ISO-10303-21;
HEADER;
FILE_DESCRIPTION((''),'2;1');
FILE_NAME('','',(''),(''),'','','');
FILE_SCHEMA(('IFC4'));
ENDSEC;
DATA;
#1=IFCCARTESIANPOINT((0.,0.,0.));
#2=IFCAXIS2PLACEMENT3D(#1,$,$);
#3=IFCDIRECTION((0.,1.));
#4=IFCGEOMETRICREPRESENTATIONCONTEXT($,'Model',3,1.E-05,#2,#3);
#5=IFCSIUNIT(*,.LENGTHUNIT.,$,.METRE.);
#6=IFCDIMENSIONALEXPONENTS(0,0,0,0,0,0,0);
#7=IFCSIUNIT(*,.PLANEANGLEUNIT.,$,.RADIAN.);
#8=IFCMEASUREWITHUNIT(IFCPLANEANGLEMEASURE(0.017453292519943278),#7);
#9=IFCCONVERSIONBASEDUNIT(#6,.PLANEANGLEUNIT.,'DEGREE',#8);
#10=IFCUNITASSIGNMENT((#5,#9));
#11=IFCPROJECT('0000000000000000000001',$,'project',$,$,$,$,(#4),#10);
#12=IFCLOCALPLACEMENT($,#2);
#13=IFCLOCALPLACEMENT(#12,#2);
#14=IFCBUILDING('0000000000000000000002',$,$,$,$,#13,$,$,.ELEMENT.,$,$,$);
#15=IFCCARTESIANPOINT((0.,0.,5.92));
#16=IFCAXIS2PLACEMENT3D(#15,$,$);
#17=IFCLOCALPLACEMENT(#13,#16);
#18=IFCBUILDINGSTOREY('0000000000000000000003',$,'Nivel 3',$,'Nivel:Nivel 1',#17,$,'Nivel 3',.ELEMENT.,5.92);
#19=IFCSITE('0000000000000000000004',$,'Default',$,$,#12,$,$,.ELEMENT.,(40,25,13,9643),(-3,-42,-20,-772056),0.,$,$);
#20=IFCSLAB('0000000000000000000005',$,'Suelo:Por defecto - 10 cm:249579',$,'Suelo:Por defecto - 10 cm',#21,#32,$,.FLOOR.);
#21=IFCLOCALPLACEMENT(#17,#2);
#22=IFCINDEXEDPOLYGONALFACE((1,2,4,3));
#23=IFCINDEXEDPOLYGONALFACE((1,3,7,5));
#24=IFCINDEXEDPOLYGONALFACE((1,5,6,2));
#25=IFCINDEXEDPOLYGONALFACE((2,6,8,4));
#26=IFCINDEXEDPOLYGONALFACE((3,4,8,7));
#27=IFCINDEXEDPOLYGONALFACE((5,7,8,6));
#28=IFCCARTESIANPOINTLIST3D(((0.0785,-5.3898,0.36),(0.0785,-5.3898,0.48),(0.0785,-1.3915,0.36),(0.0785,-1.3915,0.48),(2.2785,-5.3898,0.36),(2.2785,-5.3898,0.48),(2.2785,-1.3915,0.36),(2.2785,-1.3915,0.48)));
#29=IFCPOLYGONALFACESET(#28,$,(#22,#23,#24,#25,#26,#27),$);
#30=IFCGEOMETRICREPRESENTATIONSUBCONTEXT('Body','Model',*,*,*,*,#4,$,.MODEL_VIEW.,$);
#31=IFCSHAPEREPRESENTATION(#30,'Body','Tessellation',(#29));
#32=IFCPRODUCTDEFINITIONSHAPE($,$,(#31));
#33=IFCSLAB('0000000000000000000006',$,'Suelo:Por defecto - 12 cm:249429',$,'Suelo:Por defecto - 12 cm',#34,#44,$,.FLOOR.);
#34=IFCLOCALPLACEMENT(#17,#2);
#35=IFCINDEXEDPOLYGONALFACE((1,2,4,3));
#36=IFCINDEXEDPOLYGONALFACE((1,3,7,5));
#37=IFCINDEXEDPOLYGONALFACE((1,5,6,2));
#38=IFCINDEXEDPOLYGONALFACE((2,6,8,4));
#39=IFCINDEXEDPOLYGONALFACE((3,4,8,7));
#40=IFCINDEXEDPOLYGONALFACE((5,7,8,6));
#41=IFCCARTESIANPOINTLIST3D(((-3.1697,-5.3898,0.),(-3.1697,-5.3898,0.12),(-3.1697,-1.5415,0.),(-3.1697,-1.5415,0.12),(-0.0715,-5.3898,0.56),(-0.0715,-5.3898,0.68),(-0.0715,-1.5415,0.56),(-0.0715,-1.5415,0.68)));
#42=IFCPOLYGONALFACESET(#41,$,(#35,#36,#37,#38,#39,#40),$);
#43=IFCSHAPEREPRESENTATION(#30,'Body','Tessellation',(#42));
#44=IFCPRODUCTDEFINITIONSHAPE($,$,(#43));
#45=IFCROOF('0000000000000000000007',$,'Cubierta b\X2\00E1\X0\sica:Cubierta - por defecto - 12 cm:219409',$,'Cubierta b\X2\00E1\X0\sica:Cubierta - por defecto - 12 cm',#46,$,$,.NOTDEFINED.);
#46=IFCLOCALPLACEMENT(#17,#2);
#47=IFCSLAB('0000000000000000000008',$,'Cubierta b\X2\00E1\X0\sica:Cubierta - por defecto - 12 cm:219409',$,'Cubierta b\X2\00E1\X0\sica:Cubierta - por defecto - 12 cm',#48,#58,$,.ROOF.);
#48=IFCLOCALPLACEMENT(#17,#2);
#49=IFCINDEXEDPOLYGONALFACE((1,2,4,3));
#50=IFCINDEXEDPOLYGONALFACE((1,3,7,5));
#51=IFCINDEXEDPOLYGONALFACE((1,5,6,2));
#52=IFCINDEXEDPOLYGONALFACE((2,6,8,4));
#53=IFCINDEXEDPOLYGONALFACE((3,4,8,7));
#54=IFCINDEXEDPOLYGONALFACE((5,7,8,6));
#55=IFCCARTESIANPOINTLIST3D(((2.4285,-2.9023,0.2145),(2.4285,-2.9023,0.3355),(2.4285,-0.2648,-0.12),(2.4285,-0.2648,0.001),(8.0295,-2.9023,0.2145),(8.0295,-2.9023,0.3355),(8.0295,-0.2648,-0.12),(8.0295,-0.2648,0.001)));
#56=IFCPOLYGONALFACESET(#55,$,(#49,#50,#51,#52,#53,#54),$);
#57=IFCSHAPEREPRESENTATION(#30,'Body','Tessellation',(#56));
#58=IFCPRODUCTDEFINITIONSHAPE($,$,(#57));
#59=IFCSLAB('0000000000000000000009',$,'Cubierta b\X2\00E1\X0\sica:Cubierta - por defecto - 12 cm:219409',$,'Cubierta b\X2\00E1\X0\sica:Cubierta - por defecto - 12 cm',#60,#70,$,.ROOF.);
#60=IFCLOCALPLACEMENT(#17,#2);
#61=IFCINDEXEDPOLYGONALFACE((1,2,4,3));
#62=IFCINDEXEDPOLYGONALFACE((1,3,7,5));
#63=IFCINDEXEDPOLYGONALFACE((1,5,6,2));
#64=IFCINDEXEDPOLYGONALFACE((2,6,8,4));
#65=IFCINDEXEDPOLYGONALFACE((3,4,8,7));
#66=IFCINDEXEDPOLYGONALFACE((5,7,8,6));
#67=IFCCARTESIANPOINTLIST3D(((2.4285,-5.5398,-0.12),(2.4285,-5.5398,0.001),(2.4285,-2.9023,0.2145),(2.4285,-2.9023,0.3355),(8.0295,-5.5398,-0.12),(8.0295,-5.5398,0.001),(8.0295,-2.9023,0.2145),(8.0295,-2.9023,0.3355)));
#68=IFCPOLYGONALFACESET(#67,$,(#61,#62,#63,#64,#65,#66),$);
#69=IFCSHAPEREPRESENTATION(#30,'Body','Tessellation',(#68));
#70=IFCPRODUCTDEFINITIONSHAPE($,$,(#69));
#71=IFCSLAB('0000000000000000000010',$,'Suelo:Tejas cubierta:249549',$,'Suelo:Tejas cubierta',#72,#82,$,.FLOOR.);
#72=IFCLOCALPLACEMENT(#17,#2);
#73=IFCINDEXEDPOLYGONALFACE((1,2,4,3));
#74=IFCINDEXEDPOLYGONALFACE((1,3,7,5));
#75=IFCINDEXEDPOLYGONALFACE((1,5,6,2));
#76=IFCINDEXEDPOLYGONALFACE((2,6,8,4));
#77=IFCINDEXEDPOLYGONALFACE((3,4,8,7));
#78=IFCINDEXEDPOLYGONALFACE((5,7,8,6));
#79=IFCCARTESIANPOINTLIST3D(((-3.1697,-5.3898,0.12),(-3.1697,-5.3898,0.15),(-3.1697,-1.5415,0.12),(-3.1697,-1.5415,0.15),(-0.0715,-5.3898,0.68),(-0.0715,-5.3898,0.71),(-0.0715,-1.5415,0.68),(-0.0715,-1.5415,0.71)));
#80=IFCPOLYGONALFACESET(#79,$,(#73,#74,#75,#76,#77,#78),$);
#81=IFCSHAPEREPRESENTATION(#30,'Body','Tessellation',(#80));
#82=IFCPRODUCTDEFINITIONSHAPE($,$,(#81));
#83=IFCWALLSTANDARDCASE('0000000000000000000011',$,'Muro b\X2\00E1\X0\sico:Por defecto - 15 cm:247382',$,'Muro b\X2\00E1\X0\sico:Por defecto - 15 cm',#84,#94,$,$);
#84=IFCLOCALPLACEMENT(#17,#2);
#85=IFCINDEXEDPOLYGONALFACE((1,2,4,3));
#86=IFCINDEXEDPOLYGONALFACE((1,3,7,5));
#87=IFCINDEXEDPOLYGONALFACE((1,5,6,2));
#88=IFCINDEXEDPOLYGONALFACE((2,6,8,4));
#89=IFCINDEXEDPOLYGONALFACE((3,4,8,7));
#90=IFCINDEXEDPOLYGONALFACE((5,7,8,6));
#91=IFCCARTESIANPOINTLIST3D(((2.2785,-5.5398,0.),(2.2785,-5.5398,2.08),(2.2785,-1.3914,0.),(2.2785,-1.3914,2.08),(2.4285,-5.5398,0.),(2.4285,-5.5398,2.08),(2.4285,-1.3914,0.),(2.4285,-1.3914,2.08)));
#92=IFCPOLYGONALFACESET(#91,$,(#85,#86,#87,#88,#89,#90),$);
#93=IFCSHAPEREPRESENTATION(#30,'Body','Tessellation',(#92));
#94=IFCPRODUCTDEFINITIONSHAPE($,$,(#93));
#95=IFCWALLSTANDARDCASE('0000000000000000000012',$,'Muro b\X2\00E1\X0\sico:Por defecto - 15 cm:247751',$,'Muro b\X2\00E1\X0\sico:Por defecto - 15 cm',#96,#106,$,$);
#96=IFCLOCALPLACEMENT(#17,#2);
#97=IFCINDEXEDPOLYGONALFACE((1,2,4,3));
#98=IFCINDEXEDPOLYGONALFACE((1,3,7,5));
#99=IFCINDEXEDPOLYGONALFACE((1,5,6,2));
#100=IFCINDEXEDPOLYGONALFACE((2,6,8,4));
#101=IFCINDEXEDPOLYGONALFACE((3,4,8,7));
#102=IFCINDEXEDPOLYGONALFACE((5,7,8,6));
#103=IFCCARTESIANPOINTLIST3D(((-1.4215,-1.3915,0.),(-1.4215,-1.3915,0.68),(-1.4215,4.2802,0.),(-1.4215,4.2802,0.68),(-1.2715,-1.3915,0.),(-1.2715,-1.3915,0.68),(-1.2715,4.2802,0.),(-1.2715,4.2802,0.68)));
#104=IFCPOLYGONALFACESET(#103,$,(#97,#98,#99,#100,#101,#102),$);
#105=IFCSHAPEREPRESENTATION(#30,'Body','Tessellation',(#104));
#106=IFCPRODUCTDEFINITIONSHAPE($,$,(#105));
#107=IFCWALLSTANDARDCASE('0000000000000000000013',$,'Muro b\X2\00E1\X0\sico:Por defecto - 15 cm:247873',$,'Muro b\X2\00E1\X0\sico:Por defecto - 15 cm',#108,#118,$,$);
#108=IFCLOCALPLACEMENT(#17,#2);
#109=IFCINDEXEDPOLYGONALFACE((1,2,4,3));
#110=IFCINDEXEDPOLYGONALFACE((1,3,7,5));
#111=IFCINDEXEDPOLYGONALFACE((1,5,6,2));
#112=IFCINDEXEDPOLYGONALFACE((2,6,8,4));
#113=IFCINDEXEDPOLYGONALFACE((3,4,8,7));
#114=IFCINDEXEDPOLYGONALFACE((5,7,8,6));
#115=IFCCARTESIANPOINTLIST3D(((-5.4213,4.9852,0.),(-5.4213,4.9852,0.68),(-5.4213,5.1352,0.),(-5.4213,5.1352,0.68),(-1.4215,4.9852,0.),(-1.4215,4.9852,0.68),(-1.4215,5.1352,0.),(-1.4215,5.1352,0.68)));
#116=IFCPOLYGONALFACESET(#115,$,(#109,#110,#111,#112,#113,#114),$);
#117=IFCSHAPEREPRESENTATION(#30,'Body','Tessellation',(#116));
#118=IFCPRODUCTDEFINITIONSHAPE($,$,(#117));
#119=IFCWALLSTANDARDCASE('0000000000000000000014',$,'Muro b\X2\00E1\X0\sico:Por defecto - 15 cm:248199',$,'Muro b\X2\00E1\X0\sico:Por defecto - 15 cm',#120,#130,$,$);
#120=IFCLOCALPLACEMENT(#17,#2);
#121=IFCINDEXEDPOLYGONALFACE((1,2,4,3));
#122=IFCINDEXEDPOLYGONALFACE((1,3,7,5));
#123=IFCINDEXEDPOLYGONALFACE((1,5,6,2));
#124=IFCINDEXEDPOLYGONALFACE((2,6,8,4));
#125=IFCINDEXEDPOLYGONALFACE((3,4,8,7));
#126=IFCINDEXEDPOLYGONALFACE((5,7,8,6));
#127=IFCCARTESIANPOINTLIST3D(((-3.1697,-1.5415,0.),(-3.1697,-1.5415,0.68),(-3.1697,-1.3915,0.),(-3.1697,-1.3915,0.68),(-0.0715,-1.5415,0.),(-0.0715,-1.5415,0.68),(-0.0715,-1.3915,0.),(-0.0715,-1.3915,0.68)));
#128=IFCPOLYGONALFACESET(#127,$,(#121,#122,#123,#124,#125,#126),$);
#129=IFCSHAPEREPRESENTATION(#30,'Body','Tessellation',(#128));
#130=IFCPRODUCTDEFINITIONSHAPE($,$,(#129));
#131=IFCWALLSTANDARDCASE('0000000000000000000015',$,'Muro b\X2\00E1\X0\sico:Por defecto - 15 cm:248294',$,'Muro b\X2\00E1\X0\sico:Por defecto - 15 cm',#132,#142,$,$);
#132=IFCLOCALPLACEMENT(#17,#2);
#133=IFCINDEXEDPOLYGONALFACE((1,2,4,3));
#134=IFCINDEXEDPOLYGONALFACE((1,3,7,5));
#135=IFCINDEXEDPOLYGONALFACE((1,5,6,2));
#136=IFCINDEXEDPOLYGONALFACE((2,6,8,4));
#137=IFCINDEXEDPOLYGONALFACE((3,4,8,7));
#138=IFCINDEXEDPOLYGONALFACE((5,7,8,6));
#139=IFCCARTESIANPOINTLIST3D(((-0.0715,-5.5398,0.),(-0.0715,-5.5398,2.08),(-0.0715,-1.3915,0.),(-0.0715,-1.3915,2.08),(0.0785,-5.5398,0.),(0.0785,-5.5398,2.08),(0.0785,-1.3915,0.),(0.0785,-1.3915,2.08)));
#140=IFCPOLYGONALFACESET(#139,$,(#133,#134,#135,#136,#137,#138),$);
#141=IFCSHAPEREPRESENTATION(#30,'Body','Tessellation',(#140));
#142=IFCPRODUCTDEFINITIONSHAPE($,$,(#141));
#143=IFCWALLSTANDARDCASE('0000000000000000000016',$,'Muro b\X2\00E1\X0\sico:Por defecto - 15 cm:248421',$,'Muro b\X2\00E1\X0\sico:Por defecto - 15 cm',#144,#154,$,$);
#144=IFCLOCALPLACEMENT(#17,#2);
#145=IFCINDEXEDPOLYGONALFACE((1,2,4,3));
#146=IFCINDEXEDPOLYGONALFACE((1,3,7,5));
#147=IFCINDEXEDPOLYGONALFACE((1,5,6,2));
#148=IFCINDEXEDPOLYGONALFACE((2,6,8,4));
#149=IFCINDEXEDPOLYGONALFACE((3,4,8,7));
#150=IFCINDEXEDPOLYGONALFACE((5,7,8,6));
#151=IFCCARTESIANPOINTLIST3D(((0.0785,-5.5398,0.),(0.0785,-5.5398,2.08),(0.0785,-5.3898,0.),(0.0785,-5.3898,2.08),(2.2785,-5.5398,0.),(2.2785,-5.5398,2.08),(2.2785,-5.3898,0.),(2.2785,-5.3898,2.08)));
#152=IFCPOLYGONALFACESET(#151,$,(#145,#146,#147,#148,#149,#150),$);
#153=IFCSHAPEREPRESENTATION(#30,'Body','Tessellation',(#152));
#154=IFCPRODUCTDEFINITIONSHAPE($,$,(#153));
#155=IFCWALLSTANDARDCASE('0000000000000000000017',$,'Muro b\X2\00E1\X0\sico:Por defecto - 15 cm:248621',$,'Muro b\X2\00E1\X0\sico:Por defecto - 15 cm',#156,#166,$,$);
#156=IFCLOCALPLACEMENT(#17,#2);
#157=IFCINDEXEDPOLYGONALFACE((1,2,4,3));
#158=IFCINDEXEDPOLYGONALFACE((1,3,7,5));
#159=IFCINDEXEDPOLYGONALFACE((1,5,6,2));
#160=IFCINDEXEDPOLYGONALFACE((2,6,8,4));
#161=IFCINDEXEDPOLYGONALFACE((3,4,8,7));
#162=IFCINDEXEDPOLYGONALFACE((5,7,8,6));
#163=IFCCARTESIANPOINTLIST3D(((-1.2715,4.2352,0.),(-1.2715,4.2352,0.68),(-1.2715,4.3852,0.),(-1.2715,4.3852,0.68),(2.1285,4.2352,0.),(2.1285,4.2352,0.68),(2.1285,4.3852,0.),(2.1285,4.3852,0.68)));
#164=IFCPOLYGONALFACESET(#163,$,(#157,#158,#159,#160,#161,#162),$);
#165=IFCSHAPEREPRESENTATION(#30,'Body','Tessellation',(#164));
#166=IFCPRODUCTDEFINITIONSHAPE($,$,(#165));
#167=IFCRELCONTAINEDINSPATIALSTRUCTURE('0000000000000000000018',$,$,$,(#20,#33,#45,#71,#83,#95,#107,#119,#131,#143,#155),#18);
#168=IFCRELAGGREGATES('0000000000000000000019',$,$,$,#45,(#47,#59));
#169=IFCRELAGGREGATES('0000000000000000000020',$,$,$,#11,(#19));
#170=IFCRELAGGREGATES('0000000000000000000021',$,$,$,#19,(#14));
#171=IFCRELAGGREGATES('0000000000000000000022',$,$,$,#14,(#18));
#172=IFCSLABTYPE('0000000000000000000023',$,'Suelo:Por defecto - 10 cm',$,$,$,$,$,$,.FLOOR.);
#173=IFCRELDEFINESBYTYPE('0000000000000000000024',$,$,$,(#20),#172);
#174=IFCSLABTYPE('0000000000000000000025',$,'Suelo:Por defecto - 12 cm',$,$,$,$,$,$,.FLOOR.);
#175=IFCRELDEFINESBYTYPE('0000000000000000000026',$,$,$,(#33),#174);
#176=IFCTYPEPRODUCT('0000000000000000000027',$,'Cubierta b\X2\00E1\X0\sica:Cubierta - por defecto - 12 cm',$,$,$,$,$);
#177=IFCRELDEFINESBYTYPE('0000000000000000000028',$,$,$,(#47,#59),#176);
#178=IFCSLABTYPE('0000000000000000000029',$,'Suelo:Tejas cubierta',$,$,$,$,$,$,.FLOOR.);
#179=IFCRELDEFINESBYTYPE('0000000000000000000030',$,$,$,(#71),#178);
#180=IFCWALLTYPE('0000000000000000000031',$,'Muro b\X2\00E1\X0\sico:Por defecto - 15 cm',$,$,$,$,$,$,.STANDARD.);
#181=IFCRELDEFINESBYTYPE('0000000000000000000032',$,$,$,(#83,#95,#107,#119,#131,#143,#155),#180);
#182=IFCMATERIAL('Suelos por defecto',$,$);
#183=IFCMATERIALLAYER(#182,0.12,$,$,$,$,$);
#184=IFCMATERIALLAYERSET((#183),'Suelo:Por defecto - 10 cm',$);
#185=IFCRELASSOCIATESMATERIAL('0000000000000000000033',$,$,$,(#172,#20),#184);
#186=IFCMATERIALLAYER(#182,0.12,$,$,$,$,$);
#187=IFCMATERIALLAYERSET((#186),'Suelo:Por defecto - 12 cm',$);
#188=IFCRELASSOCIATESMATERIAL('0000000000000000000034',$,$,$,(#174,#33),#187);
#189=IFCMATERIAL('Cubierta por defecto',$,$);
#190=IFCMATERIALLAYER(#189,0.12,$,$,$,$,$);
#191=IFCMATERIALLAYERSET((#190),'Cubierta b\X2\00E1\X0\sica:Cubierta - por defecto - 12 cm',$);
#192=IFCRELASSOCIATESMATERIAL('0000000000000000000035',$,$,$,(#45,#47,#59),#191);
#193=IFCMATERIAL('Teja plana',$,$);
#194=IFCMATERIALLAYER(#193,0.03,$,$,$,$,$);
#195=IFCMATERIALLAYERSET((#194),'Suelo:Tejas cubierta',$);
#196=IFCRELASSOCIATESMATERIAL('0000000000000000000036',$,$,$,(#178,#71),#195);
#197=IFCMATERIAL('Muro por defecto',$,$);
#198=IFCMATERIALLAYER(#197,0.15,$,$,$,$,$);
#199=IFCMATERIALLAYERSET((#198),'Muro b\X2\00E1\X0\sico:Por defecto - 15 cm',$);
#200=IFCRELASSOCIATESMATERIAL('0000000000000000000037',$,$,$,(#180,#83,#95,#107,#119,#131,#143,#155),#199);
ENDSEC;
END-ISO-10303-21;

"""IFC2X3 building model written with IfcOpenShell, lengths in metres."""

from ifc_helpers import new_model, entity, si_unit, converted_unit, direction, frame, frame_2d, origin, place, context, subcontext, project, spatial, rectangle, extrude, clip, halfspace, material, layer, layer_set, layer_usage, type_object, element, aggregate, save


model = new_model("IFC2X3")

# Units and contexts
model_context = context("Model", 3, precision=1e-05, world=origin(), true_north=direction((0.0, 1.0)))
body_context = subcontext(model_context, "Body", "Model", "MODEL_VIEW")
ifc_project = project(units=[si_unit("LENGTHUNIT", "METRE"), converted_unit("PLANEANGLEUNIT", "DEGREE", entity("IfcPlaneAngleMeasure", 0.017453292519943278), si_unit("PLANEANGLEUNIT", "RADIAN"), dimensions=[0, 0, 0, 0, 0, 0, 0])], contexts=[model_context])

# Site, building, storey
site_placement = place(None, origin())
site = spatial("IfcSite", under=ifc_project, at=site_placement, Name="Default", CompositionType="ELEMENT", RefLatitude=(40, 25, 13, 9643), RefLongitude=(-3, -42, -20, -772056), RefElevation=0.0)
building_placement = place(site_placement, origin())
building = spatial("IfcBuilding", under=site, at=building_placement, CompositionType="ELEMENT")
storey_placement = place(building_placement, frame((0.0, 0.0, 5.92)))
storey = spatial("IfcBuildingStorey", under=building, at=storey_placement, Name="Nivel 3", ObjectType="Nivel:Nivel 1", LongName="Nivel 3", CompositionType="ELEMENT", Elevation=5.92)

# Slabs
ifc_material_1 = material(Name="Suelos por defecto")
ifc_layer_1 = layer(ifc_material_1, 0.12)
ifc_layer_set_1 = layer_set([ifc_layer_1], Name="Suelo:Por defecto - 10 cm")
ifc_layer_usage_1 = layer_usage(ifc_layer_set_1, "AXIS3", "POSITIVE", 0.0)
slab_type_1 = type_object("IfcSlabType", Name="Suelo:Por defecto - 10 cm", PredefinedType="FLOOR", material=ifc_layer_set_1)
slab_1_placement = place(storey_placement, origin())
element("IfcSlab", 1, at=slab_1_placement, inside=storey, type_object=slab_type_1, material=ifc_layer_usage_1, Name="Suelo:Por defecto - 10 cm:249579", ObjectType="Suelo:Por defecto - 10 cm", PredefinedType="FLOOR", context=body_context, shape_type="SweptSolid", body=[
    extrude(rectangle(XDim=3.9982, YDim=2.2, at=frame_2d((0.0, 0.0), x_axis=(1.0, 0.0))), frame((1.1785, -3.3906, 0.48), z_axis=(0.0, 0.0, -1.0), x_axis=(0.0, 1.0, 0.0)), (0.0, 0.0, 1.0), 0.12),
])
ifc_layer_2 = layer(ifc_material_1, 0.12)
ifc_layer_set_2 = layer_set([ifc_layer_2], Name="Suelo:Por defecto - 12 cm")
slab_type_2 = type_object("IfcSlabType", Name="Suelo:Por defecto - 12 cm", PredefinedType="FLOOR", material=ifc_layer_set_2)
ifc_layer_usage_2 = layer_usage(ifc_layer_set_2, "AXIS3", "POSITIVE", 0.0)
slab_2_placement = place(storey_placement, origin())
element("IfcSlab", 2, at=slab_2_placement, inside=storey, type_object=slab_type_2, material=ifc_layer_usage_2, Name="Suelo:Por defecto - 12 cm:249429", ObjectType="Suelo:Por defecto - 12 cm", PredefinedType="FLOOR", context=body_context, shape_type="SweptSolid", body=[
    clip(clip(extrude(rectangle(XDim=3.1484, YDim=3.8482, at=frame_2d((0.0, 0.0), x_axis=(0.0, 1.0))), frame((-1.6206, -3.4656, 0.4), z_axis=(0.177866, 0.0, -0.984055), x_axis=(0.0, 1.0, 0.0)), (0.0, -0.177866, 0.984055), 0.1219), halfspace(frame((-1.6206, -3.4656, 0.28), z_axis=(0.177866, 0.0, -0.984055), x_axis=(0.0, -1.0, 0.0)), False)), halfspace(frame((-1.6206, -3.4656, 0.4), z_axis=(-0.177866, 0.0, 0.984055), x_axis=(0.0, -1.0, 0.0)), False)),
])

# Roof, slabs
ifc_material_2 = material(Name="Cubierta por defecto")
ifc_layer_3 = layer(ifc_material_2, 0.12)
ifc_layer_set_3 = layer_set([ifc_layer_3], Name="Cubierta básica:Cubierta - por defecto - 12 cm")
roof_placement = place(storey_placement, frame((2.4285, -5.5398, -0.12)))
roof = element("IfcRoof", 3, at=roof_placement, inside=storey, material=ifc_layer_set_3, Name="Cubierta básica:Cubierta - por defecto - 12 cm:219409", ObjectType="Cubierta básica:Cubierta - por defecto - 12 cm", ShapeType="NOTDEFINED")
type_product = type_object("IfcTypeProduct", Name="Cubierta básica:Cubierta - por defecto - 12 cm")
slab_3_placement = place(roof_placement, origin())
slab_3 = element("IfcSlab", 4, at=slab_3_placement, type_object=type_product, material=ifc_layer_set_3, Name="Cubierta básica:Cubierta - por defecto - 12 cm:219409", ObjectType="Cubierta básica:Cubierta - por defecto - 12 cm", PredefinedType="ROOF", context=body_context, shape_type="SweptSolid", body=[
    extrude(rectangle(XDim=2.6586, YDim=5.601, at=frame_2d((0.0, 0.0), x_axis=(0.0, -1.0))), frame((2.8005, 3.9562, 0.1673), z_axis=(0.0, 0.125829, 0.992052), x_axis=(1.0, 0.0, 0.0)), (0.0, -0.125829, 0.992052), 0.121),
])
slab_4_placement = place(roof_placement, origin())
slab_4 = element("IfcSlab", 5, at=slab_4_placement, type_object=type_product, material=ifc_layer_set_3, Name="Cubierta básica:Cubierta - por defecto - 12 cm:219409", ObjectType="Cubierta básica:Cubierta - por defecto - 12 cm", PredefinedType="ROOF", context=body_context, shape_type="SweptSolid", body=[
    extrude(rectangle(XDim=5.601, YDim=2.6586, at=frame_2d((0.0, 0.0), x_axis=(-1.0, 0.0))), frame((2.8005, 1.3187, 0.1673), z_axis=(0.0, -0.125829, 0.992052), x_axis=(1.0, 0.0, 0.0)), (0.0, 0.125829, 0.992052), 0.121),
])
aggregate(roof, [slab_3, slab_4])

# Slab
ifc_material_3 = material(Name="Teja plana")
ifc_layer_4 = layer(ifc_material_3, 0.03)
ifc_layer_set_4 = layer_set([ifc_layer_4], Name="Suelo:Tejas cubierta")
ifc_layer_usage_3 = layer_usage(ifc_layer_set_4, "AXIS3", "POSITIVE", 0.0)
slab_type_3 = type_object("IfcSlabType", Name="Suelo:Tejas cubierta", PredefinedType="FLOOR", material=ifc_layer_set_4)
slab_5_placement = place(storey_placement, origin())
element("IfcSlab", 6, at=slab_5_placement, inside=storey, type_object=slab_type_3, material=ifc_layer_usage_3, Name="Suelo:Tejas cubierta:249549", ObjectType="Suelo:Tejas cubierta", PredefinedType="FLOOR", context=body_context, shape_type="SweptSolid", body=[
    clip(clip(extrude(rectangle(XDim=3.1484, YDim=3.8482, at=frame_2d((0.0, 0.0), x_axis=(0.0, 1.0))), frame((-1.6206, -3.4656, 0.43), z_axis=(0.177866, 0.0, -0.984055), x_axis=(0.0, 1.0, 0.0)), (0.0, -0.177866, 0.984055), 0.0305), halfspace(frame((-1.6206, -3.4656, 0.4), z_axis=(0.177866, 0.0, -0.984055), x_axis=(0.0, -1.0, 0.0)), False)), halfspace(frame((-1.6206, -3.4656, 0.43), z_axis=(-0.177866, 0.0, 0.984055), x_axis=(0.0, -1.0, 0.0)), False)),
])

# Walls
ifc_material_4 = material(Name="Muro por defecto")
ifc_layer_5 = layer(ifc_material_4, 0.15)
ifc_layer_set_5 = layer_set([ifc_layer_5], Name="Muro básico:Por defecto - 15 cm")
ifc_layer_usage_4 = layer_usage(ifc_layer_set_5, "AXIS2", "POSITIVE", -0.075)
wall_type = type_object("IfcWallType", Name="Muro básico:Por defecto - 15 cm", PredefinedType="STANDARD", material=ifc_layer_set_5)
wall_1_placement = place(storey_placement, frame((2.3535, -5.5398, 0.0), z_axis=(0.0, 0.0, 1.0), x_axis=(0.0, 1.0, 0.0)))
element("IfcWallStandardCase", 7, at=wall_1_placement, inside=storey, type_object=wall_type, material=ifc_layer_usage_4, Name="Muro básico:Por defecto - 15 cm:247382", ObjectType="Muro básico:Por defecto - 15 cm", context=body_context, shape_type="SweptSolid", body=[
    extrude(rectangle(XDim=4.1484, YDim=0.15, at=frame_2d((2.0742, 0.0), x_axis=(-1.0, 0.0))), origin(), (0.0, 0.0, 1.0), 2.08),
])
ifc_layer_usage_5 = layer_usage(ifc_layer_set_5, "AXIS2", "NEGATIVE", 0.075)
wall_2_placement = place(storey_placement, frame((-1.3465, -1.3915, 0.0), z_axis=(0.0, 0.0, 1.0), x_axis=(0.0, 1.0, 0.0)))
element("IfcWallStandardCase", 8, at=wall_2_placement, inside=storey, type_object=wall_type, material=ifc_layer_usage_5, Name="Muro básico:Por defecto - 15 cm:247751", ObjectType="Muro básico:Por defecto - 15 cm", context=body_context, shape_type="SweptSolid", body=[
    extrude(rectangle(XDim=5.6718, YDim=0.15, at=frame_2d((2.8359, 0.0), x_axis=(-1.0, 0.0))), origin(), (0.0, 0.0, 1.0), 0.68),
])
ifc_layer_usage_6 = layer_usage(ifc_layer_set_5, "AXIS2", "POSITIVE", -0.075)
wall_3_placement = place(storey_placement, frame((-1.4215, 5.0602, 0.0), z_axis=(0.0, 0.0, 1.0), x_axis=(-1.0, 0.0, 0.0)))
element("IfcWallStandardCase", 9, at=wall_3_placement, inside=storey, type_object=wall_type, material=ifc_layer_usage_6, Name="Muro básico:Por defecto - 15 cm:247873", ObjectType="Muro básico:Por defecto - 15 cm", context=body_context, shape_type="SweptSolid", body=[
    extrude(rectangle(XDim=3.9998, YDim=0.15, at=frame_2d((1.9999, 0.0), x_axis=(-1.0, 0.0))), origin(), (0.0, 0.0, 1.0), 0.68),
])
ifc_layer_usage_7 = layer_usage(ifc_layer_set_5, "AXIS2", "NEGATIVE", 0.075)
wall_4_placement = place(storey_placement, frame((-0.0715, -1.4665, 0.0), z_axis=(0.0, 0.0, 1.0), x_axis=(-1.0, 0.0, 0.0)))
element("IfcWallStandardCase", 10, at=wall_4_placement, inside=storey, type_object=wall_type, material=ifc_layer_usage_7, Name="Muro básico:Por defecto - 15 cm:248199", ObjectType="Muro básico:Por defecto - 15 cm", context=body_context, shape_type="SweptSolid", body=[
    extrude(rectangle(XDim=3.0982, YDim=0.15, at=frame_2d((1.5491, 0.0), x_axis=(-1.0, 0.0))), origin(), (0.0, 0.0, 1.0), 0.68),
])
ifc_layer_usage_8 = layer_usage(ifc_layer_set_5, "AXIS2", "POSITIVE", -0.075)
wall_5_placement = place(storey_placement, frame((0.0035, -5.5398, 0.0), z_axis=(0.0, 0.0, 1.0), x_axis=(0.0, 1.0, 0.0)))
element("IfcWallStandardCase", 11, at=wall_5_placement, inside=storey, type_object=wall_type, material=ifc_layer_usage_8, Name="Muro básico:Por defecto - 15 cm:248294", ObjectType="Muro básico:Por defecto - 15 cm", context=body_context, shape_type="SweptSolid", body=[
    extrude(rectangle(XDim=4.1482, YDim=0.15, at=frame_2d((2.0741, 0.0), x_axis=(-1.0, 0.0))), origin(), (0.0, 0.0, 1.0), 2.08),
])
ifc_layer_usage_9 = layer_usage(ifc_layer_set_5, "AXIS2", "POSITIVE", -0.075)
wall_6_placement = place(storey_placement, frame((0.0785, -5.4648, 0.0)))
element("IfcWallStandardCase", 12, at=wall_6_placement, inside=storey, type_object=wall_type, material=ifc_layer_usage_9, Name="Muro básico:Por defecto - 15 cm:248421", ObjectType="Muro básico:Por defecto - 15 cm", context=body_context, shape_type="SweptSolid", body=[
    extrude(rectangle(XDim=2.2, YDim=0.15, at=frame_2d((1.1, 0.0), x_axis=(-1.0, 0.0))), origin(), (0.0, 0.0, 1.0), 2.08),
])
ifc_layer_usage_10 = layer_usage(ifc_layer_set_5, "AXIS2", "NEGATIVE", 0.075)
wall_7_placement = place(storey_placement, frame((-1.2715, 4.3102, 0.0)))
element("IfcWallStandardCase", 13, at=wall_7_placement, inside=storey, type_object=wall_type, material=ifc_layer_usage_10, Name="Muro básico:Por defecto - 15 cm:248621", ObjectType="Muro básico:Por defecto - 15 cm", context=body_context, shape_type="SweptSolid", body=[
    extrude(rectangle(XDim=3.4, YDim=0.15, at=frame_2d((1.7, 0.0), x_axis=(-1.0, 0.0))), origin(), (0.0, 0.0, 1.0), 0.68),
])

save(model, "model.ifc")
